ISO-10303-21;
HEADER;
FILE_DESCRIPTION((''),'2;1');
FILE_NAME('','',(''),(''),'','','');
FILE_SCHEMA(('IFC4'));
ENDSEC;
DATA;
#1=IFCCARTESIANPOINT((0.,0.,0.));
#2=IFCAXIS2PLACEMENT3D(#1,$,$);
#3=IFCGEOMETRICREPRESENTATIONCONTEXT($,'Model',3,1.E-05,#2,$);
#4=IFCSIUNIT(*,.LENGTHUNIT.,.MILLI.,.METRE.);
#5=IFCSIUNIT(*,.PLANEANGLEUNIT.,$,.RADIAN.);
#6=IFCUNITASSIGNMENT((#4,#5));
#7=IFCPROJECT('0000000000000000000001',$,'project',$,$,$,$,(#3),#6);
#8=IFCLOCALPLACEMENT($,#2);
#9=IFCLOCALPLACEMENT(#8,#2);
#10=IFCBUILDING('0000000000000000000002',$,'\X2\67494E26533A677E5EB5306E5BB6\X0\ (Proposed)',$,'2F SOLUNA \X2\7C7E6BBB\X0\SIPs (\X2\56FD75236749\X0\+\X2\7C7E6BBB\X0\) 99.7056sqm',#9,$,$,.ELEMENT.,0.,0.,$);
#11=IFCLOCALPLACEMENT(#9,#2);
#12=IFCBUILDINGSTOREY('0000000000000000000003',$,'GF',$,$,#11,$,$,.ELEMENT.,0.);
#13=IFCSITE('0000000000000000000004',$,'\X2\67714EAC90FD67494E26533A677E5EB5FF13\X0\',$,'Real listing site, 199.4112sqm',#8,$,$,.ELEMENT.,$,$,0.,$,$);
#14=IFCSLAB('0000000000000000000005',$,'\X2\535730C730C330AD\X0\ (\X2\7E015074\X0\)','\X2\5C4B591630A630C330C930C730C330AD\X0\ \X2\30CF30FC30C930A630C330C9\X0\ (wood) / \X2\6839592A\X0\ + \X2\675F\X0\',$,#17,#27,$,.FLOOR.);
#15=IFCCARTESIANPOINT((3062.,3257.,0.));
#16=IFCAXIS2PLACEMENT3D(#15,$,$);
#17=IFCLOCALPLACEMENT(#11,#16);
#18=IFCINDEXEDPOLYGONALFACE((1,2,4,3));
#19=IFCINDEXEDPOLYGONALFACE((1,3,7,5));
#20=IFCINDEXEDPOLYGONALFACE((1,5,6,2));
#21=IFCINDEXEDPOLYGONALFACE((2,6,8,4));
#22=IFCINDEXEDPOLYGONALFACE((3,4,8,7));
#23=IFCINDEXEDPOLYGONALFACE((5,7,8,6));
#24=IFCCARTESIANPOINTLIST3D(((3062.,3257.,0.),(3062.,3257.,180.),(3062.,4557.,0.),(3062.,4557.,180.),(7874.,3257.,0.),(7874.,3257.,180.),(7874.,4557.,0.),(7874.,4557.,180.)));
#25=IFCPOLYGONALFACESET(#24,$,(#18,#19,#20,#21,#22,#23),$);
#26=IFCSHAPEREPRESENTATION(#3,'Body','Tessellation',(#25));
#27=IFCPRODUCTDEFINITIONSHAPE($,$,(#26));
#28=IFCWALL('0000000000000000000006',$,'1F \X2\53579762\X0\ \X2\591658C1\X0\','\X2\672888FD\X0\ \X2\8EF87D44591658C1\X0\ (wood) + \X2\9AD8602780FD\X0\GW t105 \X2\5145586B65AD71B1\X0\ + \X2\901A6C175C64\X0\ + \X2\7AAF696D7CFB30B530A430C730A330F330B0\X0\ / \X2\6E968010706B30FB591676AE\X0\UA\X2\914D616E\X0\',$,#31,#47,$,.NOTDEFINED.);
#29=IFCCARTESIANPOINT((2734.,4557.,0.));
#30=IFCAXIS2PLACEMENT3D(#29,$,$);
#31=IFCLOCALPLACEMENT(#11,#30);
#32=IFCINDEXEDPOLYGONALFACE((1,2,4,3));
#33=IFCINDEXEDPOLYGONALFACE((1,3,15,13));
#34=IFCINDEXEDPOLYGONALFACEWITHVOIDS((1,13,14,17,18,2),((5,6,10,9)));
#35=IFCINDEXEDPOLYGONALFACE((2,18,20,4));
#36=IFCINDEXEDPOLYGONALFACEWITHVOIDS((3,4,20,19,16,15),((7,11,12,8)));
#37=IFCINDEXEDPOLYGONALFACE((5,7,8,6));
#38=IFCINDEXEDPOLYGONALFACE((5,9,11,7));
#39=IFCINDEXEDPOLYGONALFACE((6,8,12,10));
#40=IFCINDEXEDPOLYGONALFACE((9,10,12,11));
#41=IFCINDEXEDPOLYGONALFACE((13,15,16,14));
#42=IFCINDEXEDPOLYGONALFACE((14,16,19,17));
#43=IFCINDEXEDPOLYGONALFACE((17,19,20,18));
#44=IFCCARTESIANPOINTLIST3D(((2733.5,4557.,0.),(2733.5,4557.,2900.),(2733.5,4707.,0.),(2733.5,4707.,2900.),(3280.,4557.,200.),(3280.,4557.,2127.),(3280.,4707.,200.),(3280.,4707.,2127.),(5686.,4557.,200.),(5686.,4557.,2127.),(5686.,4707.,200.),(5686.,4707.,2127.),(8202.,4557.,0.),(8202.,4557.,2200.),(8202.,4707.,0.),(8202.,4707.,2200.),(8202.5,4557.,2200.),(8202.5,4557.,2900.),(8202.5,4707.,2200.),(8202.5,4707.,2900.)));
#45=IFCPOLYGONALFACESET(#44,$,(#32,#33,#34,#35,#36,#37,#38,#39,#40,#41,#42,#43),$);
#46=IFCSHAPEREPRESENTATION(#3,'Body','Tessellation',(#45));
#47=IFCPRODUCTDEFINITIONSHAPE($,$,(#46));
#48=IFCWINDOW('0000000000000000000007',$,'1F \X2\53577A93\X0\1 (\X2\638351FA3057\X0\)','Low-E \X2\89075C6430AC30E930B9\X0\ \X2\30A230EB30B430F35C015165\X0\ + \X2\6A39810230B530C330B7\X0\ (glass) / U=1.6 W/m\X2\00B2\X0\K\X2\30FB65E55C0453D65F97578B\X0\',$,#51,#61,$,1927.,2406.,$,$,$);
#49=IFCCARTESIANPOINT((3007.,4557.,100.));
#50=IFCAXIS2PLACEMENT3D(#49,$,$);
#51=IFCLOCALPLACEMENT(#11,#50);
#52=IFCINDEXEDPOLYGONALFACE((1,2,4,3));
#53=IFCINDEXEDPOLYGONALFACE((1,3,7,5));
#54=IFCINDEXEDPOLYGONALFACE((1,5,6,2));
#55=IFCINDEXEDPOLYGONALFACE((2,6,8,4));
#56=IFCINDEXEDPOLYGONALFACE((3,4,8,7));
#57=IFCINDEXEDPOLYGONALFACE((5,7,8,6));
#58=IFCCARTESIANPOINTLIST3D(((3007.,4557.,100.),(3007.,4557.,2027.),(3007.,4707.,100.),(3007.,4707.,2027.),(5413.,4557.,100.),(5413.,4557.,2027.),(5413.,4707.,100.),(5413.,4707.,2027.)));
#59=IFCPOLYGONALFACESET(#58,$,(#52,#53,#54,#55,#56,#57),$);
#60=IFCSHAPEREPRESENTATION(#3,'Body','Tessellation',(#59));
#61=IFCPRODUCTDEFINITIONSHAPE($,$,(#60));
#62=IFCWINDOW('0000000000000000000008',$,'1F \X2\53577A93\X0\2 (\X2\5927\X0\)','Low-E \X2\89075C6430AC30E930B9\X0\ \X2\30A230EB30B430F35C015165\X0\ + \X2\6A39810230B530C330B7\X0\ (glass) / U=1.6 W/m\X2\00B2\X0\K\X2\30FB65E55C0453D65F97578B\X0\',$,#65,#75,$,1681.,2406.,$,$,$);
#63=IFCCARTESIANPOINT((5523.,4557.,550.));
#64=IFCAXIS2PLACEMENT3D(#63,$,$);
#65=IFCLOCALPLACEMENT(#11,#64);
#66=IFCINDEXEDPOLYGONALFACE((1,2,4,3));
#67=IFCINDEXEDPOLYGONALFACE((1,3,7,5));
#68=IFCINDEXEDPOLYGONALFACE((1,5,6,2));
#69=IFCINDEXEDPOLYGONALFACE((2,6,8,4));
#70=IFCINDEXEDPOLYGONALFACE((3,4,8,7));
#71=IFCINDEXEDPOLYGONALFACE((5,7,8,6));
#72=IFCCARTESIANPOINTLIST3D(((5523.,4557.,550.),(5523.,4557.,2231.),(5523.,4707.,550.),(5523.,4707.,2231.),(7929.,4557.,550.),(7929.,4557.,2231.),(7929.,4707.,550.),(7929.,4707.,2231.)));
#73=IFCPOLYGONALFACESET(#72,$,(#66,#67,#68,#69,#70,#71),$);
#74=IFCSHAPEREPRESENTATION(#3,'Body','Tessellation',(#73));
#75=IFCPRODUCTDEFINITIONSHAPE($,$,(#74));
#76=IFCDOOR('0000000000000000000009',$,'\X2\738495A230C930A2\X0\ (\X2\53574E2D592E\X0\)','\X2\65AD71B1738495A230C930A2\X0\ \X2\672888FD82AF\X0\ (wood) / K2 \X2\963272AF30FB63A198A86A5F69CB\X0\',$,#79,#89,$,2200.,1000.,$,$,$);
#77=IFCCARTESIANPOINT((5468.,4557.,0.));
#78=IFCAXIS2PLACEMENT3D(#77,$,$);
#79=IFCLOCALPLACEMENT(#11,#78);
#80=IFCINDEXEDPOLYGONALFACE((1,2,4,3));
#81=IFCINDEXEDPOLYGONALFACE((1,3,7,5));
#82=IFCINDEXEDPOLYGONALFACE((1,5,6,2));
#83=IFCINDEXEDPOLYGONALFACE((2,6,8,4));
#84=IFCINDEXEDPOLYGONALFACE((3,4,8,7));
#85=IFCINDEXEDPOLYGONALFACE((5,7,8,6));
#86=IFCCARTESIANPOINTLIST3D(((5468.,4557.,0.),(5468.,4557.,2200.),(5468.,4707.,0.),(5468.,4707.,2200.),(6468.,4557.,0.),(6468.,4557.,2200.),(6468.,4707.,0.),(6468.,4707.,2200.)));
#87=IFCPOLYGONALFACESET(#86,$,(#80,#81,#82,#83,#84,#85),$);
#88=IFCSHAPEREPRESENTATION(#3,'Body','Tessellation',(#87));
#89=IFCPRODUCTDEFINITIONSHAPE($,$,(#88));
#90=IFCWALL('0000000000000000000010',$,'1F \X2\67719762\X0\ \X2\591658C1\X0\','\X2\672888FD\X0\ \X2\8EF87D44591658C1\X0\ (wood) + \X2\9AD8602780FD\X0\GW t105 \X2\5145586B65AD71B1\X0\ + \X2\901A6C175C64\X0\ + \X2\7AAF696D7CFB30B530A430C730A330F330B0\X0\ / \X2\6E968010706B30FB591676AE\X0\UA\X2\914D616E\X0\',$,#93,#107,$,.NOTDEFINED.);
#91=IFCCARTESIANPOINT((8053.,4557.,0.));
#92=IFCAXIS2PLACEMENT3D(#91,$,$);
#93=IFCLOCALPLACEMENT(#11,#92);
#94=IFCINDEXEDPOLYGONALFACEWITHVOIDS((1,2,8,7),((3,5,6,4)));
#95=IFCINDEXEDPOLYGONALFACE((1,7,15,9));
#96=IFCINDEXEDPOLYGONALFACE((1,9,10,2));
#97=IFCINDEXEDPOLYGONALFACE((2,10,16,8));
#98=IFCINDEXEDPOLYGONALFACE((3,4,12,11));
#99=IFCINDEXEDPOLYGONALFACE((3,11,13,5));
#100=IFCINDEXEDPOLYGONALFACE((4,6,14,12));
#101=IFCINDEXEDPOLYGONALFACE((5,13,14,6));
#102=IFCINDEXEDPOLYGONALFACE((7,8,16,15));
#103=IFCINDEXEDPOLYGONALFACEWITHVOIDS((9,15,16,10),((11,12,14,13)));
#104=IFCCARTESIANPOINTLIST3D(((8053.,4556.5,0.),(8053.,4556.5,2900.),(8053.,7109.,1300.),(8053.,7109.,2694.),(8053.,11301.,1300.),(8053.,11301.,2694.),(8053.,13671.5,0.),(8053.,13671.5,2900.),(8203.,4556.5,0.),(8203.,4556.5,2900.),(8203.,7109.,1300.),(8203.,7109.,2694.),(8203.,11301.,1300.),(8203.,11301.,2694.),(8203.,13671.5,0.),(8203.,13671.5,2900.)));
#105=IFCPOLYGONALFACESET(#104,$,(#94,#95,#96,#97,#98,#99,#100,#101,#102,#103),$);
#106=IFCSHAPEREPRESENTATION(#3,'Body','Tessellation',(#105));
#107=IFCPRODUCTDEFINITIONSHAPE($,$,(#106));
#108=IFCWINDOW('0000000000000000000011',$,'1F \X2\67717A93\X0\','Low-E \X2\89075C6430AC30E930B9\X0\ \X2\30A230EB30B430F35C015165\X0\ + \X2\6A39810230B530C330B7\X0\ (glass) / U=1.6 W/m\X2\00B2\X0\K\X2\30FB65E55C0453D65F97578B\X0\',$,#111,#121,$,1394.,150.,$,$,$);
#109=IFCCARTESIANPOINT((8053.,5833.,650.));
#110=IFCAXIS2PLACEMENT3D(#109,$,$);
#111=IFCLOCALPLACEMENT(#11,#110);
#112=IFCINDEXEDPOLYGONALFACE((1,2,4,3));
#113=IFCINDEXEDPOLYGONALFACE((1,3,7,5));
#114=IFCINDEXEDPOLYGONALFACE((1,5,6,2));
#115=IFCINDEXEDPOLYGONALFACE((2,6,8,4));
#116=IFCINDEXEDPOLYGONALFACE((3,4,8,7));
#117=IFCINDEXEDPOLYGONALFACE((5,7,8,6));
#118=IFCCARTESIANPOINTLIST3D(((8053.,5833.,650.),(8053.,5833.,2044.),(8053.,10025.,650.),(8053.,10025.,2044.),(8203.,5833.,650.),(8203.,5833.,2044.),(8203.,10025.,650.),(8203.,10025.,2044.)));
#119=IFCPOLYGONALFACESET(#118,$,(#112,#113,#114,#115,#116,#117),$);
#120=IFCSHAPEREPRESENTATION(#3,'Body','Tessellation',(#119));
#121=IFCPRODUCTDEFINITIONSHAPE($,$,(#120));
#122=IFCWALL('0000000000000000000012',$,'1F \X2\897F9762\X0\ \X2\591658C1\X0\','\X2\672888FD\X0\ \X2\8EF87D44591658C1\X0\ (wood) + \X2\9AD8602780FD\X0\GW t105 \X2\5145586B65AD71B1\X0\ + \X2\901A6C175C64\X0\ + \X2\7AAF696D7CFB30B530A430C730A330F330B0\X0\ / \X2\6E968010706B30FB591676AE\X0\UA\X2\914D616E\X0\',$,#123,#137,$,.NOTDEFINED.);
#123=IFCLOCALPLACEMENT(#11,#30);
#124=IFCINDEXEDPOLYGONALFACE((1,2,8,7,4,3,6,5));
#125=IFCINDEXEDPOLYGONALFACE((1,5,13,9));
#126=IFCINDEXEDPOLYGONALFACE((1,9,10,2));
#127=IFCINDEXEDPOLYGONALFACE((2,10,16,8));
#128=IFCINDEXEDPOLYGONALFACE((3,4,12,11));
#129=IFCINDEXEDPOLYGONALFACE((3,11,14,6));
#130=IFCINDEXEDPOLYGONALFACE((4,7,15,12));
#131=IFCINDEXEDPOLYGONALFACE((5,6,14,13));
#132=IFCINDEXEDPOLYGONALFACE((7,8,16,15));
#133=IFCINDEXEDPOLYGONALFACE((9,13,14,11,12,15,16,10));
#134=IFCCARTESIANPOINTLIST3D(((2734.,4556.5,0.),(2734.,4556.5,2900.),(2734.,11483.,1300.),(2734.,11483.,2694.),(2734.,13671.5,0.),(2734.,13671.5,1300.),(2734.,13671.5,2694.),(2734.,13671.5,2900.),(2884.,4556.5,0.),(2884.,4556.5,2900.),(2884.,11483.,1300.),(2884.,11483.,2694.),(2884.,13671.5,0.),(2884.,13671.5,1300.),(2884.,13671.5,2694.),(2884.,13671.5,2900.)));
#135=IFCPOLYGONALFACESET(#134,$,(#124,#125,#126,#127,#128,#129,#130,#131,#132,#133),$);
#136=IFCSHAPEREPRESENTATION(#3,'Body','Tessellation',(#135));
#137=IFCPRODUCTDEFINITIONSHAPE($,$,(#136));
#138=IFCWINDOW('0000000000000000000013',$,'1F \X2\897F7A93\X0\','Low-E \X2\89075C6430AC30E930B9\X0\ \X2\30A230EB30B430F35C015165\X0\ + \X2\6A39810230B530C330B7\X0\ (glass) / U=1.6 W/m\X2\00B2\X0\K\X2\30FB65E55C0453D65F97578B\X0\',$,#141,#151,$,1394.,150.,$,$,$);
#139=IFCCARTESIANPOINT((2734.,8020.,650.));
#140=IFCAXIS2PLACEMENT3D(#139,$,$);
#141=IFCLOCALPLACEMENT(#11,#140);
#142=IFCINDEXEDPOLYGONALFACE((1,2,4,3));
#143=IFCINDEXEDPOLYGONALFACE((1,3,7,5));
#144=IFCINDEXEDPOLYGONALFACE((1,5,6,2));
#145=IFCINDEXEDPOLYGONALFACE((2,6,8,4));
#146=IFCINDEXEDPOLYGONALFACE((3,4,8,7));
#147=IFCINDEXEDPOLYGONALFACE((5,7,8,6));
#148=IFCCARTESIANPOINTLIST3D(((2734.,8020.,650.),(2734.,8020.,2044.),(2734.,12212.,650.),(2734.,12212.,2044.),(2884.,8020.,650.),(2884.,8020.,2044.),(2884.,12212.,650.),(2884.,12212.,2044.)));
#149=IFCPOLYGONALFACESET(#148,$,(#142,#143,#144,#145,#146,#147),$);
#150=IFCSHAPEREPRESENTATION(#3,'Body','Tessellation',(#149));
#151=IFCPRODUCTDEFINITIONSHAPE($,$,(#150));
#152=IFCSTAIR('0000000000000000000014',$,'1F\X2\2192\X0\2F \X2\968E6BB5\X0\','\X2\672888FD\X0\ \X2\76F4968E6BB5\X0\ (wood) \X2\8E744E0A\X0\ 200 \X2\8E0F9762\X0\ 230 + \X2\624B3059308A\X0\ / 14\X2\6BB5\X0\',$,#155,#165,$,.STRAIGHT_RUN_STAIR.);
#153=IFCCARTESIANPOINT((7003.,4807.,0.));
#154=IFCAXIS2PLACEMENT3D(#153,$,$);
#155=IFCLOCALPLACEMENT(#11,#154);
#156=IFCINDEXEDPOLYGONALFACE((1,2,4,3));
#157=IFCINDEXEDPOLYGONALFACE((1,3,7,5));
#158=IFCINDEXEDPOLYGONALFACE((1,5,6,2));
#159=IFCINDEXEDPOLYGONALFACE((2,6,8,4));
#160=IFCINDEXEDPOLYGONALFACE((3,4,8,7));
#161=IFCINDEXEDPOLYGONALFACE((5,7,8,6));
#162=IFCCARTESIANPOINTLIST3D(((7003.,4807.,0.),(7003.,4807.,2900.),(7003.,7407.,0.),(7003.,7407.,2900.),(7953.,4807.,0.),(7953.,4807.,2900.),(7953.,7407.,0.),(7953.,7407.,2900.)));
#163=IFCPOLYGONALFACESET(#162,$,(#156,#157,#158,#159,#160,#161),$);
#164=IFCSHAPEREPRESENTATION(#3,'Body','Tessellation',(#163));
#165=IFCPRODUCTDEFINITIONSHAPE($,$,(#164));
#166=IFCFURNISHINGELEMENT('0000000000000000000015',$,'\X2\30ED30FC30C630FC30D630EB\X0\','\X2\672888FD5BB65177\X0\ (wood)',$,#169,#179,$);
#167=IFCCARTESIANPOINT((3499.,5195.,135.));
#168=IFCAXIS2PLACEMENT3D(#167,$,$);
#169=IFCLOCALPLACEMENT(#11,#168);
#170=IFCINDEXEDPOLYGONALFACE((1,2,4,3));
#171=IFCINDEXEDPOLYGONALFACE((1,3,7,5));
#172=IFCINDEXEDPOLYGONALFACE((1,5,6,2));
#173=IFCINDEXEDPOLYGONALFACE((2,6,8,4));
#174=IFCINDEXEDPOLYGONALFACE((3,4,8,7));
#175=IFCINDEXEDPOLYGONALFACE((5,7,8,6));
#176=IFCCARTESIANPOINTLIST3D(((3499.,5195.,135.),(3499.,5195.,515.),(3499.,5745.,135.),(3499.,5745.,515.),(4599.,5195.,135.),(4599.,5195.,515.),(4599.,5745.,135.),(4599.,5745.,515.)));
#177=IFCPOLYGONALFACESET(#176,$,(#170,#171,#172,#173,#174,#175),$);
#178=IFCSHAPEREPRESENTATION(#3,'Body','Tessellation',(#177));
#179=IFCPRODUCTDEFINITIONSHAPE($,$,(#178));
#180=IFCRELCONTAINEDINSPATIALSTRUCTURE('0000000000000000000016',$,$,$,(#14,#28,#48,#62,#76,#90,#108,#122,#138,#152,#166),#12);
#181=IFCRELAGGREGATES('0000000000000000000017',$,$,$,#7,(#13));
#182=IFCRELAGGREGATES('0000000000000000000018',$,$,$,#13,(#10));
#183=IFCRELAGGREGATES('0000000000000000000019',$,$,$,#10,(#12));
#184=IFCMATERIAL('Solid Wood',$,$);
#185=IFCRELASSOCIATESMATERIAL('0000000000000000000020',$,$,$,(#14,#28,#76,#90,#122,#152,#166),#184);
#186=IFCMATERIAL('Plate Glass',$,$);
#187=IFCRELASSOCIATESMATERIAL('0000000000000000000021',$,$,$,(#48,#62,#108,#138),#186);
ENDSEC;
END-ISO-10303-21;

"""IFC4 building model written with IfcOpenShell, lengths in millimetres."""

from ifc_helpers import new_model, si_unit, frame, frame_2d, origin, place, context, project, spatial, rectangle, extrude, material, element, fill, save


model = new_model("IFC4")

# Units and contexts
model_context = context("Model", 3, precision=1e-05, world=origin())
ifc_project = project(units=[si_unit("LENGTHUNIT", "METRE", prefix="MILLI"), si_unit("PLANEANGLEUNIT", "RADIAN")], contexts=[model_context])

# Site, building, storey
site_placement = place(None, origin())
site = spatial("IfcSite", under=ifc_project, at=site_placement, Name="東京都杉並区松庵３", ObjectType="Real listing site, 199.4112sqm", CompositionType="ELEMENT", RefElevation=0.0)
building_placement = place(site_placement, origin())
building = spatial("IfcBuilding", under=site, at=building_placement, Name="杉並区松庵の家 (Proposed)", ObjectType="2F SOLUNA 籾殻SIPs (国産杉+籾殻) 99.7056sqm", CompositionType="ELEMENT", ElevationOfRefHeight=0.0, ElevationOfTerrain=0.0)
storey_placement = place(building_placement, origin())
storey = spatial("IfcBuildingStorey", under=building, at=storey_placement, Name="GF", CompositionType="ELEMENT", Elevation=0.0)

# Slab
ifc_material_1 = material(Name="Solid Wood")
slab_1_placement = place(storey_placement, frame((3062.0, 3257.0, 0.0)))
element("IfcSlab", 1, at=slab_1_placement, inside=storey, material=ifc_material_1, Name="南デッキ (縁側)", Description="屋外ウッドデッキ ハードウッド (wood) / 根太 + 束", PredefinedType="FLOOR", context=model_context, shape_type="SweptSolid", body=[
    extrude(rectangle(XDim=4812.0, YDim=1300.0, at=frame_2d((2406.0, 650.0))), frame((3062.0, 3257.0, 0.0)), (0.0, 0.0, 1.0), 180.0),
])

# Wall, openings, windows, door
wall_1_placement = place(storey_placement, frame((2734.0, 4557.0, 0.0)))
wall_1 = element("IfcWall", 2, at=wall_1_placement, inside=storey, material=ifc_material_1, Name="1F 南面 外壁", Description="木製 軸組外壁 (wood) + 高性能GW t105 充填断熱 + 通気層 + 窯業系サイディング / 準耐火・外皮UA配慮", PredefinedType="NOTDEFINED", context=model_context, shape_type="SweptSolid", body=[
    extrude(rectangle(XDim=5469.0, YDim=150.0, at=frame_2d((2734.0, 75.0))), frame((2734.0, 4557.0, 0.0)), (0.0, 0.0, 1.0), 2900.0),
])
opening_1_placement = place(storey_placement, frame((3007.0, 4557.0, 100.0)))
opening_1 = element("IfcOpeningElement", 3, at=opening_1_placement, cuts=wall_1, PredefinedType="NOTDEFINED", context=model_context, shape_type="SweptSolid", body=[
    extrude(rectangle(XDim=2406.0, YDim=150.0, at=frame_2d((1203.0, 75.0))), frame((3007.0, 4557.0, 100.0)), (0.0, 0.0, 1.0), 1927.0),
])
opening_2_placement = place(storey_placement, frame((5523.0, 4557.0, 550.0)))
opening_2 = element("IfcOpeningElement", 4, at=opening_2_placement, cuts=wall_1, PredefinedType="NOTDEFINED", context=model_context, shape_type="SweptSolid", body=[
    extrude(rectangle(XDim=2406.0, YDim=150.0, at=frame_2d((1203.0, 75.0))), frame((5523.0, 4557.0, 550.0)), (0.0, 0.0, 1.0), 1681.0),
])
opening_3_placement = place(storey_placement, frame((5468.0, 4557.0, 0.0)))
opening_3 = element("IfcOpeningElement", 5, at=opening_3_placement, cuts=wall_1, PredefinedType="NOTDEFINED", context=model_context, shape_type="SweptSolid", body=[
    extrude(rectangle(XDim=1000.0, YDim=150.0, at=frame_2d((500.0, 75.0))), frame((5468.0, 4557.0, 0.0)), (0.0, 0.0, 1.0), 2200.0),
])
ifc_material_2 = material(Name="Plate Glass")
window_1_placement = place(storey_placement, frame((3007.0, 4557.0, 100.0)))
window_1 = element("IfcWindow", 6, at=window_1_placement, inside=storey, material=ifc_material_2, Name="1F 南窓1 (掃出し)", Description="Low-E 複層ガラス アルゴン封入 + 樹脂サッシ (glass) / U=1.6 W/m²K・日射取得型", OverallHeight=1927.0, OverallWidth=2406.0, context=model_context, shape_type="SweptSolid", body=[
    extrude(rectangle(XDim=2406.0, YDim=150.0, at=frame_2d((1203.0, 75.0))), frame((3007.0, 4557.0, 100.0)), (0.0, 0.0, 1.0), 1927.0),
])
fill(opening_1, window_1)
window_2_placement = place(storey_placement, frame((5523.0, 4557.0, 550.0)))
window_2 = element("IfcWindow", 7, at=window_2_placement, inside=storey, material=ifc_material_2, Name="1F 南窓2 (大)", Description="Low-E 複層ガラス アルゴン封入 + 樹脂サッシ (glass) / U=1.6 W/m²K・日射取得型", OverallHeight=1681.0, OverallWidth=2406.0, context=model_context, shape_type="SweptSolid", body=[
    extrude(rectangle(XDim=2406.0, YDim=150.0, at=frame_2d((1203.0, 75.0))), frame((5523.0, 4557.0, 550.0)), (0.0, 0.0, 1.0), 1681.0),
])
fill(opening_2, window_2)
door_placement = place(storey_placement, frame((5468.0, 4557.0, 0.0)))
door = element("IfcDoor", 8, at=door_placement, inside=storey, material=ifc_material_1, Name="玄関ドア (南中央)", Description="断熱玄関ドア 木製芯 (wood) / K2 防犯・採風機構", OverallHeight=2200.0, OverallWidth=1000.0, context=model_context, shape_type="SweptSolid", body=[
    extrude(rectangle(XDim=1000.0, YDim=150.0, at=frame_2d((500.0, 75.0))), frame((5468.0, 4557.0, 0.0)), (0.0, 0.0, 1.0), 2200.0),
])
fill(opening_3, door)

# Walls, openings, windows
wall_2_placement = place(storey_placement, frame((8053.0, 4557.0, 0.0)))
wall_2 = element("IfcWall", 9, at=wall_2_placement, inside=storey, material=ifc_material_1, Name="1F 東面 外壁", Description="木製 軸組外壁 (wood) + 高性能GW t105 充填断熱 + 通気層 + 窯業系サイディング / 準耐火・外皮UA配慮", PredefinedType="NOTDEFINED", context=model_context, shape_type="SweptSolid", body=[
    extrude(rectangle(XDim=150.0, YDim=9115.0, at=frame_2d((75.0, 4557.0))), frame((8053.0, 4557.0, 0.0)), (0.0, 0.0, 1.0), 2900.0),
])
opening_4_placement = place(storey_placement, frame((8053.0, 5833.0, 650.0)))
opening_4 = element("IfcOpeningElement", 10, at=opening_4_placement, cuts=wall_2, PredefinedType="NOTDEFINED", context=model_context, shape_type="SweptSolid", body=[
    extrude(rectangle(XDim=150.0, YDim=4192.0, at=frame_2d((75.0, 2096.0))), frame((8053.0, 5833.0, 650.0)), (0.0, 0.0, 1.0), 1394.0),
])
window_3_placement = place(storey_placement, frame((8053.0, 5833.0, 650.0)))
window_3 = element("IfcWindow", 11, at=window_3_placement, inside=storey, material=ifc_material_2, Name="1F 東窓", Description="Low-E 複層ガラス アルゴン封入 + 樹脂サッシ (glass) / U=1.6 W/m²K・日射取得型", OverallHeight=1394.0, OverallWidth=150.0, context=model_context, shape_type="SweptSolid", body=[
    extrude(rectangle(XDim=150.0, YDim=4192.0, at=frame_2d((75.0, 2096.0))), frame((8053.0, 5833.0, 650.0)), (0.0, 0.0, 1.0), 1394.0),
])
fill(opening_4, window_3)
wall_3_placement = place(storey_placement, frame((2734.0, 4557.0, 0.0)))
wall_3 = element("IfcWall", 12, at=wall_3_placement, inside=storey, material=ifc_material_1, Name="1F 西面 外壁", Description="木製 軸組外壁 (wood) + 高性能GW t105 充填断熱 + 通気層 + 窯業系サイディング / 準耐火・外皮UA配慮", PredefinedType="NOTDEFINED", context=model_context, shape_type="SweptSolid", body=[
    extrude(rectangle(XDim=150.0, YDim=9115.0, at=frame_2d((75.0, 4557.0))), frame((2734.0, 4557.0, 0.0)), (0.0, 0.0, 1.0), 2900.0),
])
opening_5_placement = place(storey_placement, frame((2734.0, 8020.0, 650.0)))
opening_5 = element("IfcOpeningElement", 13, at=opening_5_placement, cuts=wall_3, PredefinedType="NOTDEFINED", context=model_context, shape_type="SweptSolid", body=[
    extrude(rectangle(XDim=150.0, YDim=4192.0, at=frame_2d((75.0, 2096.0))), frame((2734.0, 8020.0, 650.0)), (0.0, 0.0, 1.0), 1394.0),
])
window_4_placement = place(storey_placement, frame((2734.0, 8020.0, 650.0)))
window_4 = element("IfcWindow", 14, at=window_4_placement, inside=storey, material=ifc_material_2, Name="1F 西窓", Description="Low-E 複層ガラス アルゴン封入 + 樹脂サッシ (glass) / U=1.6 W/m²K・日射取得型", OverallHeight=1394.0, OverallWidth=150.0, context=model_context, shape_type="SweptSolid", body=[
    extrude(rectangle(XDim=150.0, YDim=4192.0, at=frame_2d((75.0, 2096.0))), frame((2734.0, 8020.0, 650.0)), (0.0, 0.0, 1.0), 1394.0),
])
fill(opening_5, window_4)

# Stair
stair_placement = place(storey_placement, frame((7003.0, 4807.0, 0.0)))
element("IfcStair", 15, at=stair_placement, inside=storey, material=ifc_material_1, Name="1F→2F 階段", Description="木製 直階段 (wood) 蹴上 200 踏面 230 + 手すり / 14段", PredefinedType="STRAIGHT_RUN_STAIR", context=model_context, shape_type="SweptSolid", body=[
    extrude(rectangle(XDim=950.0, YDim=2600.0, at=frame_2d((475.0, 1300.0))), frame((7003.0, 4807.0, 0.0)), (0.0, 0.0, 1.0), 2900.0),
])

# Furnishing element
furnishing_1_placement = place(storey_placement, frame((3499.0, 5195.0, 135.0)))
element("IfcFurnishingElement", 16, at=furnishing_1_placement, inside=storey, material=ifc_material_1, Name="ローテーブル", Description="木製家具 (wood)", context=model_context, shape_type="SweptSolid", body=[
    extrude(rectangle(XDim=1100.0, YDim=550.0, at=frame_2d((550.0, 275.0))), frame((3499.0, 5195.0, 135.0)), (0.0, 0.0, 1.0), 380.0),
])

save(model, "model.ifc")
